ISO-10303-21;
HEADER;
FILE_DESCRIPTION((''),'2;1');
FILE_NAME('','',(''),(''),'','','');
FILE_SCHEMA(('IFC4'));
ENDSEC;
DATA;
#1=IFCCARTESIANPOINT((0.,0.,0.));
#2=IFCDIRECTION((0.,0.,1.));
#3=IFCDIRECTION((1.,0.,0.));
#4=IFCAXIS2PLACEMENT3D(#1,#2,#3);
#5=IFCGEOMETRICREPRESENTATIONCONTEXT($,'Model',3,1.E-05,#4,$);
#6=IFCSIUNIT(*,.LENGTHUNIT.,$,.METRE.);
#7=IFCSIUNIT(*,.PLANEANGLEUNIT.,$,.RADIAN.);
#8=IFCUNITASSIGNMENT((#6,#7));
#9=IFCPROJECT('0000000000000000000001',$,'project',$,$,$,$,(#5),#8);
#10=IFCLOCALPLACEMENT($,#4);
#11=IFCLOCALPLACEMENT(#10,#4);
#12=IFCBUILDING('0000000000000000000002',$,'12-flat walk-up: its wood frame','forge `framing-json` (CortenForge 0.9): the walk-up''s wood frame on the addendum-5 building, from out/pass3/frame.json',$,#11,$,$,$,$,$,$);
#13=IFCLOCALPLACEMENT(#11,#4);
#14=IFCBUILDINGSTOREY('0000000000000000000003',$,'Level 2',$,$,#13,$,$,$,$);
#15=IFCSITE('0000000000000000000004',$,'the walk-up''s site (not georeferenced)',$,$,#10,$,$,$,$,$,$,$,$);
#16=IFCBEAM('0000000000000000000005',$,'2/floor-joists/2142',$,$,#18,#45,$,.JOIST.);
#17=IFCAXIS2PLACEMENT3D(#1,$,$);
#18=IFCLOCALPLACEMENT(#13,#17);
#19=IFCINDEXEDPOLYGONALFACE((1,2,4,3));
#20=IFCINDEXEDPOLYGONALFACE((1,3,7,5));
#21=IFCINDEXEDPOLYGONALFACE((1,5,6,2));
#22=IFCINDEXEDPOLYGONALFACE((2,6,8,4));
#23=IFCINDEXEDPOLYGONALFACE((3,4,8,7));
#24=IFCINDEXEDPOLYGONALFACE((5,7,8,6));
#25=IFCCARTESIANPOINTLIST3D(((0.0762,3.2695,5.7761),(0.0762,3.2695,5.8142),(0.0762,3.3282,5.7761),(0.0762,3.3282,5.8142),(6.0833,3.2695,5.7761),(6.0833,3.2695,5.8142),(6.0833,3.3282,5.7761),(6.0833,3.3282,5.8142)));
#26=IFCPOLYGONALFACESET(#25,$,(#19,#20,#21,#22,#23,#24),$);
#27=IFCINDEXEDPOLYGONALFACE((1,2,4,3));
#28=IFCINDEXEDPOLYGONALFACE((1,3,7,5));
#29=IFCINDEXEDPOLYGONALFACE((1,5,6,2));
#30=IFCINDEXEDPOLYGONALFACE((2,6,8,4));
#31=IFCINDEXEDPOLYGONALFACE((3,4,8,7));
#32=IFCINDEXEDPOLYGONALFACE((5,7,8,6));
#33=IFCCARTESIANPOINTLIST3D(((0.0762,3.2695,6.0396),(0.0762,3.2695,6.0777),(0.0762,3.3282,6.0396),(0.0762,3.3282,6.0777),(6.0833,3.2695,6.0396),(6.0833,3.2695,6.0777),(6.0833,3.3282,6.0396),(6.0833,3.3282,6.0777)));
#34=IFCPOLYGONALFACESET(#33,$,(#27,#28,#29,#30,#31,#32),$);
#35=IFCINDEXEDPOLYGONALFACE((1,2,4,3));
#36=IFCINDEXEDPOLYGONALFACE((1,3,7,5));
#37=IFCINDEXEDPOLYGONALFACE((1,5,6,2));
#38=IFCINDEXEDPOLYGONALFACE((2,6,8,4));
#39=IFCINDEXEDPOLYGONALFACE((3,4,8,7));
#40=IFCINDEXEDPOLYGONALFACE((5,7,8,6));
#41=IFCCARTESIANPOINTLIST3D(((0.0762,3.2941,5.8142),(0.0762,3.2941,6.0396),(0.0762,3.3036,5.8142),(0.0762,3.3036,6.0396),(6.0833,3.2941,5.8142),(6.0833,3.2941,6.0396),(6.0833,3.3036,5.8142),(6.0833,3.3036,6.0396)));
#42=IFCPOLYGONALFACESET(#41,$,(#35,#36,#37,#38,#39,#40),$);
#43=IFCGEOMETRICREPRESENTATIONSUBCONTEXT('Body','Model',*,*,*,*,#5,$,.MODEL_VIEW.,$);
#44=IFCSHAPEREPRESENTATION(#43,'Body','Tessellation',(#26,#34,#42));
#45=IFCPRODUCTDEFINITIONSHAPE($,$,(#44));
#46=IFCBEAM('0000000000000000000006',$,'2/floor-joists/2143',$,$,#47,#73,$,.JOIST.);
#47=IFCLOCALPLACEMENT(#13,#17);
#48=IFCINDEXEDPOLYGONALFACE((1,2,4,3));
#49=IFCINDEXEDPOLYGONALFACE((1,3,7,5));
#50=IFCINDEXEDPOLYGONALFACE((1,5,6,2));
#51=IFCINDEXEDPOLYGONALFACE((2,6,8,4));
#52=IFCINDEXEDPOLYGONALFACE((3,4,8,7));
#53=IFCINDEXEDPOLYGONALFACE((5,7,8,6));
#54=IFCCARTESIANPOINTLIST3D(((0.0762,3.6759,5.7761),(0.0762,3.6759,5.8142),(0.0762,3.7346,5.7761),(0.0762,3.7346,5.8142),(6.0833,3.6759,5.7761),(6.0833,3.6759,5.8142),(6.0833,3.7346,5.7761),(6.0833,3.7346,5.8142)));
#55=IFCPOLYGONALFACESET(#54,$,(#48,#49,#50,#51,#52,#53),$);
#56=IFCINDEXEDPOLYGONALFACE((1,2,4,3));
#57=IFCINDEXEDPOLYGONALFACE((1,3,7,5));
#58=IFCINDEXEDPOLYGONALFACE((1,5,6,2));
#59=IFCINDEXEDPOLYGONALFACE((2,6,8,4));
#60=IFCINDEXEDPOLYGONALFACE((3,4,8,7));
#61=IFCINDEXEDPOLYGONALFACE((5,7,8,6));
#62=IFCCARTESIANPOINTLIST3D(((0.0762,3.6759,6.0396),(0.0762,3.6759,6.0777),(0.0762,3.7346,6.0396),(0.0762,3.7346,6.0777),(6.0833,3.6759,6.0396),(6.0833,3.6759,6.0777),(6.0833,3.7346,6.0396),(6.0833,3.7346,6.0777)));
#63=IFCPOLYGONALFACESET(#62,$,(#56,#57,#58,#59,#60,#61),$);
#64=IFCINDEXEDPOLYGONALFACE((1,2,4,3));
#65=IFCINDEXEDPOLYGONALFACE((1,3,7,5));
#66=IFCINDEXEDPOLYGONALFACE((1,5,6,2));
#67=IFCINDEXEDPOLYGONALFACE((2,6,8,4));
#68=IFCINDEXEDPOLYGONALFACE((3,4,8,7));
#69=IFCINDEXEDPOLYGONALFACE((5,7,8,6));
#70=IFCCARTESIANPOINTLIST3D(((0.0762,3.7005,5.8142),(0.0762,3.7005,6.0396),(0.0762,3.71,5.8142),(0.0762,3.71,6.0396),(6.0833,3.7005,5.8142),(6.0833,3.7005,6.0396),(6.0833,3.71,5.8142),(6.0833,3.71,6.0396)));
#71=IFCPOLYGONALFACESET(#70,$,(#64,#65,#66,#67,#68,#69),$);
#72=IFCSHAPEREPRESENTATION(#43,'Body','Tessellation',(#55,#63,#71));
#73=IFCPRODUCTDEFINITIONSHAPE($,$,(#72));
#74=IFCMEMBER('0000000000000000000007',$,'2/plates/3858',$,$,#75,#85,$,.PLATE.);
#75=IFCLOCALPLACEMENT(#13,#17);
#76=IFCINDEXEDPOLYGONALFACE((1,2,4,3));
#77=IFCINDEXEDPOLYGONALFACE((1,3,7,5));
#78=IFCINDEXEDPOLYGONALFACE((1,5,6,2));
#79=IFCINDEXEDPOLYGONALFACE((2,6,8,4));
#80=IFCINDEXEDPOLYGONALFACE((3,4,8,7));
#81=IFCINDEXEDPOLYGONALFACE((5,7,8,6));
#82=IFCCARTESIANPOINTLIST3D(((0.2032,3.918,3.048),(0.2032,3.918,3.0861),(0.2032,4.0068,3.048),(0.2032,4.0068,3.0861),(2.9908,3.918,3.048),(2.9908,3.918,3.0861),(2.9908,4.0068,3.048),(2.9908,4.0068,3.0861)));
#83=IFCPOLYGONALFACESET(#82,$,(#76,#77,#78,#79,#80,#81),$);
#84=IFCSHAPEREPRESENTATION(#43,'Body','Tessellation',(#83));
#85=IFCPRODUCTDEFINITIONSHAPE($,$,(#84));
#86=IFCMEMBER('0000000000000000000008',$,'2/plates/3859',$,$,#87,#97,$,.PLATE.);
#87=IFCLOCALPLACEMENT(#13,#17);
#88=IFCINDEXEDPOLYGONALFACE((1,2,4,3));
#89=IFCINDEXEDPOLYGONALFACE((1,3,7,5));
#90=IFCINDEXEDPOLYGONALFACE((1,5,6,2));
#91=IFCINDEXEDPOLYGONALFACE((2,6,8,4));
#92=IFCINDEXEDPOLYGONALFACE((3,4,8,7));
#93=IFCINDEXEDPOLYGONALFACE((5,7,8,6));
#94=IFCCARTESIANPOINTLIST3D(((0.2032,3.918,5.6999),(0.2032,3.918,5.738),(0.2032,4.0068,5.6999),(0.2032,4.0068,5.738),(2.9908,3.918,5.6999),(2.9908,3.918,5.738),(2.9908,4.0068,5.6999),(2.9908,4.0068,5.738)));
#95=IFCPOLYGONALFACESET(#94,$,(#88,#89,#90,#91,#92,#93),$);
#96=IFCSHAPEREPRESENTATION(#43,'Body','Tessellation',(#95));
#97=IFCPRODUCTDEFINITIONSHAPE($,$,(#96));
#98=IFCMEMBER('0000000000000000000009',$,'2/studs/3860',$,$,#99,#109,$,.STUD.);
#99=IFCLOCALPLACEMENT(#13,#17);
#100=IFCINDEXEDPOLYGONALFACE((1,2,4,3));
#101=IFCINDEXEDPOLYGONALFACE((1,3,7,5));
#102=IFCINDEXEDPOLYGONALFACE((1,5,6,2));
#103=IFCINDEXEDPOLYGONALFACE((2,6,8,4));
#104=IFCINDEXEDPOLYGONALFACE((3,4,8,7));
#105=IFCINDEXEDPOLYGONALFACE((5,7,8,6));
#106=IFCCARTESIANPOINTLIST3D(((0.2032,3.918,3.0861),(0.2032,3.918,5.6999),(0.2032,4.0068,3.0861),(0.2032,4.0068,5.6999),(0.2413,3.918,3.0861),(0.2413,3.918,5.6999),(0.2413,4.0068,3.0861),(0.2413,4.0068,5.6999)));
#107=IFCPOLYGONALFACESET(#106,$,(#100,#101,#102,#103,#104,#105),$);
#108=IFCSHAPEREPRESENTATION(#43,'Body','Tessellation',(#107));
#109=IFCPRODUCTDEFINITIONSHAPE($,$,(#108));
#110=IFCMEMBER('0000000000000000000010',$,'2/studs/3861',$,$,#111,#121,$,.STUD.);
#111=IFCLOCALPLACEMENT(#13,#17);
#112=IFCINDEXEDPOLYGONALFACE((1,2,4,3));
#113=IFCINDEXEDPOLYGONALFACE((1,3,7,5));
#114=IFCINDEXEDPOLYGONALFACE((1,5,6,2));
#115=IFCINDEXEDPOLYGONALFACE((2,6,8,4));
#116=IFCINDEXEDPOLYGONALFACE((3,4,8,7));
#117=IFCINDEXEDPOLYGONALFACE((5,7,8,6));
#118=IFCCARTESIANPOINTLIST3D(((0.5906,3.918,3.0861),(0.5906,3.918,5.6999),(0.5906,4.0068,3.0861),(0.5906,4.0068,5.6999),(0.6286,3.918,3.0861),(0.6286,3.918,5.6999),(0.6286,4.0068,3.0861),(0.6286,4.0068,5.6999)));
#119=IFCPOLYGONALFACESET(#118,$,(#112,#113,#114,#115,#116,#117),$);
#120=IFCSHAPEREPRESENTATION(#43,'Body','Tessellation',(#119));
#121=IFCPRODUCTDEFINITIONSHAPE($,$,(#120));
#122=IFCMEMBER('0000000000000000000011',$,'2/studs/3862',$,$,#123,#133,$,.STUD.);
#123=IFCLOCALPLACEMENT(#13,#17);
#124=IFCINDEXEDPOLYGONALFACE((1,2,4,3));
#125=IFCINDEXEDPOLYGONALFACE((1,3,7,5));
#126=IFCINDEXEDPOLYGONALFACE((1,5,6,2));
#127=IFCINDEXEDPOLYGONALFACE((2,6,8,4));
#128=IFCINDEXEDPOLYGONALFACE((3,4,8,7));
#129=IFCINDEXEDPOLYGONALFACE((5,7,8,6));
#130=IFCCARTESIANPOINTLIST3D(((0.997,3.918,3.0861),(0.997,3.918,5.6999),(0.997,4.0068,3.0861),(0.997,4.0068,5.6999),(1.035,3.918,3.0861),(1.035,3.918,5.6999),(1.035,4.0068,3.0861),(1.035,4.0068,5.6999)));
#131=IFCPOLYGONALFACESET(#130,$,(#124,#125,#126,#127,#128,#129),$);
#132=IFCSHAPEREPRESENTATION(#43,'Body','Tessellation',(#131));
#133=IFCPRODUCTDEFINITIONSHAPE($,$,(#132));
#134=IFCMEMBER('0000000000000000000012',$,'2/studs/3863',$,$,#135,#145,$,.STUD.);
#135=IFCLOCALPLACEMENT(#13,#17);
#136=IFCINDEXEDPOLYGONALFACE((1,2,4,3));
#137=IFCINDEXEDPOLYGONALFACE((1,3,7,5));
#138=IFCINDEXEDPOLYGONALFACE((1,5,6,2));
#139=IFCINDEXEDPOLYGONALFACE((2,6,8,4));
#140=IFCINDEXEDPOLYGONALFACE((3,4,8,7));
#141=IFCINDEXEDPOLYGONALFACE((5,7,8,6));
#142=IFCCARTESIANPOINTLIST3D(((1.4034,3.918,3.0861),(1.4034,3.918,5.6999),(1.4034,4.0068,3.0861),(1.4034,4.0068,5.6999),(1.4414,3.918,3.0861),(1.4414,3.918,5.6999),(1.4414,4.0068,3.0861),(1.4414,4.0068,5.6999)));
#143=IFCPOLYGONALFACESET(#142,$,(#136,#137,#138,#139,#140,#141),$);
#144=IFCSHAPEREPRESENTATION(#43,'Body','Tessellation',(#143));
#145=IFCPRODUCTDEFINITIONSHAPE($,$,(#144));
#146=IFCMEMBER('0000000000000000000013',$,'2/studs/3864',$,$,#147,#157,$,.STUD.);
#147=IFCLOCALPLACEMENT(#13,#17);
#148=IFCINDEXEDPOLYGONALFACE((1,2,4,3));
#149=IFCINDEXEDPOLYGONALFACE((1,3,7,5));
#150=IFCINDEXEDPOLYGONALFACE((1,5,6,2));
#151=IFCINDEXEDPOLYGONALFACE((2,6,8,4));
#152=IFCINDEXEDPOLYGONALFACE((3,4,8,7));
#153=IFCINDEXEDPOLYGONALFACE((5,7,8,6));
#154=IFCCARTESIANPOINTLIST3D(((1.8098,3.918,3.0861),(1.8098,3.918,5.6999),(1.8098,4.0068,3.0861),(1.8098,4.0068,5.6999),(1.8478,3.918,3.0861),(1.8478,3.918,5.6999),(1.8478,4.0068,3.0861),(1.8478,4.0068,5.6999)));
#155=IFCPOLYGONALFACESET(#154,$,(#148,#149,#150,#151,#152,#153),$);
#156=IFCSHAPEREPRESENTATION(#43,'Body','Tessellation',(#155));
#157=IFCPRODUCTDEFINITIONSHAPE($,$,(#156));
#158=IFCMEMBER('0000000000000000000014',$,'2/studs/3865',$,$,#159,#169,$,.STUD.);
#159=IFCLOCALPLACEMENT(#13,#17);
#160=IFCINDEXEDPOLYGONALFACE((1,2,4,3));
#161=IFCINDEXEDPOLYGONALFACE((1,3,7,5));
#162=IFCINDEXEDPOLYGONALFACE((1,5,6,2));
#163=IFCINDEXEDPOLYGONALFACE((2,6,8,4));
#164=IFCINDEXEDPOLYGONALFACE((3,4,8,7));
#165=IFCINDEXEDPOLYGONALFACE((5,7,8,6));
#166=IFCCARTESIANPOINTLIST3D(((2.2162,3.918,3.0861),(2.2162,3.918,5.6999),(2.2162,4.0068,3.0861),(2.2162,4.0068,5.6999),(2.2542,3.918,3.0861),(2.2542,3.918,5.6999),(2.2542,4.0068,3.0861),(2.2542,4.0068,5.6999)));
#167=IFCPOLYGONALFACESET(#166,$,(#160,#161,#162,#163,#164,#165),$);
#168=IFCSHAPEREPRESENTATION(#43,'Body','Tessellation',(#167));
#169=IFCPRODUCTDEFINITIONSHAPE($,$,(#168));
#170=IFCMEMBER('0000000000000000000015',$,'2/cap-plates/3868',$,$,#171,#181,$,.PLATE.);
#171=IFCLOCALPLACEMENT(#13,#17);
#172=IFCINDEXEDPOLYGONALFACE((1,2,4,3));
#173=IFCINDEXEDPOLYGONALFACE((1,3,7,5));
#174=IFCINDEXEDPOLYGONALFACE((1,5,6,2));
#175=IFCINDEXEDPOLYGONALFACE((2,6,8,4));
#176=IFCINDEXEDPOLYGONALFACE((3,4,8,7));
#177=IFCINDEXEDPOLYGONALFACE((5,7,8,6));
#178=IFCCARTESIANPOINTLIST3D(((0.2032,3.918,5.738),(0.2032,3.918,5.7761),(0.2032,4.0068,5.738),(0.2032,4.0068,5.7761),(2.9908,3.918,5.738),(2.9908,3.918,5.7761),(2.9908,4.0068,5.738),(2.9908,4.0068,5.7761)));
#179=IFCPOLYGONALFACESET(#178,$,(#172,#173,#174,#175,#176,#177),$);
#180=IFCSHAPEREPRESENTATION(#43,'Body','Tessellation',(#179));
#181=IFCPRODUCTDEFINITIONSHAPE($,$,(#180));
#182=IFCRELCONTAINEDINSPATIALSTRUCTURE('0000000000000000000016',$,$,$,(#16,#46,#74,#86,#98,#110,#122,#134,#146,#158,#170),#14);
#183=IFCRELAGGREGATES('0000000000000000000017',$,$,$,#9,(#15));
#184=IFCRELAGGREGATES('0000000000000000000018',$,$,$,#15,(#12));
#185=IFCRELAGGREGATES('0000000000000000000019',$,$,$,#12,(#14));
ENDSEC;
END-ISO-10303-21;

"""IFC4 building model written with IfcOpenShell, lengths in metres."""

from ifc_helpers import new_model, si_unit, frame, frame_2d, origin, origin_with_axes, place, context, subcontext, project, spatial, rectangle, extrude, element, save


model = new_model("IFC4")

# Units and contexts
model_context = context("Model", 3, precision=1e-05, world=origin_with_axes())
body_context = subcontext(model_context, "Body", "Model", "MODEL_VIEW")
ifc_project = project(units=[si_unit("LENGTHUNIT", "METRE"), si_unit("PLANEANGLEUNIT", "RADIAN")], contexts=[model_context])

# Site, building, storey
site_placement = place(None, origin_with_axes())
site = spatial("IfcSite", under=ifc_project, at=site_placement, Name="the walk-up's site (not georeferenced)")
building_placement = place(site_placement, origin_with_axes())
building = spatial("IfcBuilding", under=site, at=building_placement, Name="12-flat walk-up: its wood frame", Description="forge `framing-json` (CortenForge 0.9): the walk-up's wood frame on the addendum-5 building, from out/pass3/frame.json")
storey_placement = place(building_placement, origin_with_axes())
storey = spatial("IfcBuildingStorey", under=building, at=storey_placement, Name="Level 2")

# Beams
for number, where, z_axis, x_axis, name in (
    (1, (0.0762, 3.2695, 5.7761), (0.0, 0.0, 1.0), (1.0, 0.0, 0.0), "2/floor-joists/2142"),
    (2, (0.0762, 3.6759, 5.7761), (0.0, 0.0, 1.0), (1.0, 0.0, 0.0), "2/floor-joists/2143"),
):
    element("IfcBeam", number, at=place(storey_placement, frame(where, z_axis=z_axis, x_axis=x_axis)), inside=storey, Name=name, PredefinedType="JOIST", context=body_context, shape_type="SweptSolid", body=[
        extrude(rectangle(XDim=6.0071, YDim=0.0587, at=frame_2d((3.0036, 0.0294))), origin(), (0.0, 0.0, 1.0), 0.0381),
        extrude(rectangle(XDim=6.0071, YDim=0.0587, at=frame_2d((3.0036, 0.0294))), frame((0.0, 0.0, 0.2635)), (0.0, 0.0, 1.0), 0.0381),
        extrude(rectangle(XDim=6.0071, YDim=0.0095, at=frame_2d((3.0036, 0.0048))), frame((0.0, 0.0246, 0.0381)), (0.0, 0.0, 1.0), 0.2254),
    ])

# Members
for number, where, z_axis, x_axis, name in (
    (3, (0.2032, 3.9179, 3.048), (0.0, 0.0, 1.0), (1.0, 0.0, 0.0), "2/plates/3858"),
    (4, (0.2032, 3.9179, 5.6999), (0.0, 0.0, 1.0), (1.0, 0.0, 0.0), "2/plates/3859"),
):
    element("IfcMember", number, at=place(storey_placement, frame(where, z_axis=z_axis, x_axis=x_axis)), inside=storey, Name=name, PredefinedType="PLATE", context=body_context, shape_type="SweptSolid", body=[
        extrude(rectangle(XDim=2.7877, YDim=0.0889, at=frame_2d((1.3938, 0.0445))), origin(), (0.0, 0.0, 1.0), 0.0381),
    ])
member_1_placement = place(storey_placement, frame((0.2032, 3.9179, 3.0861), z_axis=(0.0, 0.0, 1.0), x_axis=(1.0, 0.0, 0.0)))
element("IfcMember", 5, at=member_1_placement, inside=storey, Name="2/studs/3860", PredefinedType="STUD", context=body_context, shape_type="SweptSolid", body=[
    extrude(rectangle(XDim=0.0381, YDim=0.0889, at=frame_2d((0.019, 0.0445))), origin(), (0.0, 0.0, 1.0), 2.6138),
])
for number, where, z_axis, x_axis, name in (
    (6, (0.5906, 3.9179, 3.0861), (0.0, 0.0, 1.0), (1.0, 0.0, 0.0), "2/studs/3861"),
    (7, (0.997, 3.9179, 3.0861), (0.0, 0.0, 1.0), (1.0, 0.0, 0.0), "2/studs/3862"),
):
    element("IfcMember", number, at=place(storey_placement, frame(where, z_axis=z_axis, x_axis=x_axis)), inside=storey, Name=name, PredefinedType="STUD", context=body_context, shape_type="SweptSolid", body=[
        extrude(rectangle(XDim=0.0381, YDim=0.0889, at=frame_2d((0.0191, 0.0445))), origin(), (0.0, 0.0, 1.0), 2.6138),
    ])
member_2_placement = place(storey_placement, frame((1.4034, 3.9179, 3.0861), z_axis=(0.0, 0.0, 1.0), x_axis=(1.0, 0.0, 0.0)))
element("IfcMember", 8, at=member_2_placement, inside=storey, Name="2/studs/3863", PredefinedType="STUD", context=body_context, shape_type="SweptSolid", body=[
    extrude(rectangle(XDim=0.0381, YDim=0.0889, at=frame_2d((0.019, 0.0445))), origin(), (0.0, 0.0, 1.0), 2.6138),
])
for number, where, z_axis, x_axis, name in (
    (9, (1.8097, 3.9179, 3.0861), (0.0, 0.0, 1.0), (1.0, 0.0, 0.0), "2/studs/3864"),
    (10, (2.2161, 3.9179, 3.0861), (0.0, 0.0, 1.0), (1.0, 0.0, 0.0), "2/studs/3865"),
):
    element("IfcMember", number, at=place(storey_placement, frame(where, z_axis=z_axis, x_axis=x_axis)), inside=storey, Name=name, PredefinedType="STUD", context=body_context, shape_type="SweptSolid", body=[
        extrude(rectangle(XDim=0.0381, YDim=0.0889, at=frame_2d((0.0191, 0.0445))), origin(), (0.0, 0.0, 1.0), 2.6138),
    ])
member_3_placement = place(storey_placement, frame((0.2032, 3.9179, 5.738), z_axis=(0.0, 0.0, 1.0), x_axis=(1.0, 0.0, 0.0)))
element("IfcMember", 11, at=member_3_placement, inside=storey, Name="2/cap-plates/3868", PredefinedType="PLATE", context=body_context, shape_type="SweptSolid", body=[
    extrude(rectangle(XDim=2.7877, YDim=0.0889, at=frame_2d((1.3938, 0.0445))), origin(), (0.0, 0.0, 1.0), 0.0381),
])

save(model, "model.ifc")
